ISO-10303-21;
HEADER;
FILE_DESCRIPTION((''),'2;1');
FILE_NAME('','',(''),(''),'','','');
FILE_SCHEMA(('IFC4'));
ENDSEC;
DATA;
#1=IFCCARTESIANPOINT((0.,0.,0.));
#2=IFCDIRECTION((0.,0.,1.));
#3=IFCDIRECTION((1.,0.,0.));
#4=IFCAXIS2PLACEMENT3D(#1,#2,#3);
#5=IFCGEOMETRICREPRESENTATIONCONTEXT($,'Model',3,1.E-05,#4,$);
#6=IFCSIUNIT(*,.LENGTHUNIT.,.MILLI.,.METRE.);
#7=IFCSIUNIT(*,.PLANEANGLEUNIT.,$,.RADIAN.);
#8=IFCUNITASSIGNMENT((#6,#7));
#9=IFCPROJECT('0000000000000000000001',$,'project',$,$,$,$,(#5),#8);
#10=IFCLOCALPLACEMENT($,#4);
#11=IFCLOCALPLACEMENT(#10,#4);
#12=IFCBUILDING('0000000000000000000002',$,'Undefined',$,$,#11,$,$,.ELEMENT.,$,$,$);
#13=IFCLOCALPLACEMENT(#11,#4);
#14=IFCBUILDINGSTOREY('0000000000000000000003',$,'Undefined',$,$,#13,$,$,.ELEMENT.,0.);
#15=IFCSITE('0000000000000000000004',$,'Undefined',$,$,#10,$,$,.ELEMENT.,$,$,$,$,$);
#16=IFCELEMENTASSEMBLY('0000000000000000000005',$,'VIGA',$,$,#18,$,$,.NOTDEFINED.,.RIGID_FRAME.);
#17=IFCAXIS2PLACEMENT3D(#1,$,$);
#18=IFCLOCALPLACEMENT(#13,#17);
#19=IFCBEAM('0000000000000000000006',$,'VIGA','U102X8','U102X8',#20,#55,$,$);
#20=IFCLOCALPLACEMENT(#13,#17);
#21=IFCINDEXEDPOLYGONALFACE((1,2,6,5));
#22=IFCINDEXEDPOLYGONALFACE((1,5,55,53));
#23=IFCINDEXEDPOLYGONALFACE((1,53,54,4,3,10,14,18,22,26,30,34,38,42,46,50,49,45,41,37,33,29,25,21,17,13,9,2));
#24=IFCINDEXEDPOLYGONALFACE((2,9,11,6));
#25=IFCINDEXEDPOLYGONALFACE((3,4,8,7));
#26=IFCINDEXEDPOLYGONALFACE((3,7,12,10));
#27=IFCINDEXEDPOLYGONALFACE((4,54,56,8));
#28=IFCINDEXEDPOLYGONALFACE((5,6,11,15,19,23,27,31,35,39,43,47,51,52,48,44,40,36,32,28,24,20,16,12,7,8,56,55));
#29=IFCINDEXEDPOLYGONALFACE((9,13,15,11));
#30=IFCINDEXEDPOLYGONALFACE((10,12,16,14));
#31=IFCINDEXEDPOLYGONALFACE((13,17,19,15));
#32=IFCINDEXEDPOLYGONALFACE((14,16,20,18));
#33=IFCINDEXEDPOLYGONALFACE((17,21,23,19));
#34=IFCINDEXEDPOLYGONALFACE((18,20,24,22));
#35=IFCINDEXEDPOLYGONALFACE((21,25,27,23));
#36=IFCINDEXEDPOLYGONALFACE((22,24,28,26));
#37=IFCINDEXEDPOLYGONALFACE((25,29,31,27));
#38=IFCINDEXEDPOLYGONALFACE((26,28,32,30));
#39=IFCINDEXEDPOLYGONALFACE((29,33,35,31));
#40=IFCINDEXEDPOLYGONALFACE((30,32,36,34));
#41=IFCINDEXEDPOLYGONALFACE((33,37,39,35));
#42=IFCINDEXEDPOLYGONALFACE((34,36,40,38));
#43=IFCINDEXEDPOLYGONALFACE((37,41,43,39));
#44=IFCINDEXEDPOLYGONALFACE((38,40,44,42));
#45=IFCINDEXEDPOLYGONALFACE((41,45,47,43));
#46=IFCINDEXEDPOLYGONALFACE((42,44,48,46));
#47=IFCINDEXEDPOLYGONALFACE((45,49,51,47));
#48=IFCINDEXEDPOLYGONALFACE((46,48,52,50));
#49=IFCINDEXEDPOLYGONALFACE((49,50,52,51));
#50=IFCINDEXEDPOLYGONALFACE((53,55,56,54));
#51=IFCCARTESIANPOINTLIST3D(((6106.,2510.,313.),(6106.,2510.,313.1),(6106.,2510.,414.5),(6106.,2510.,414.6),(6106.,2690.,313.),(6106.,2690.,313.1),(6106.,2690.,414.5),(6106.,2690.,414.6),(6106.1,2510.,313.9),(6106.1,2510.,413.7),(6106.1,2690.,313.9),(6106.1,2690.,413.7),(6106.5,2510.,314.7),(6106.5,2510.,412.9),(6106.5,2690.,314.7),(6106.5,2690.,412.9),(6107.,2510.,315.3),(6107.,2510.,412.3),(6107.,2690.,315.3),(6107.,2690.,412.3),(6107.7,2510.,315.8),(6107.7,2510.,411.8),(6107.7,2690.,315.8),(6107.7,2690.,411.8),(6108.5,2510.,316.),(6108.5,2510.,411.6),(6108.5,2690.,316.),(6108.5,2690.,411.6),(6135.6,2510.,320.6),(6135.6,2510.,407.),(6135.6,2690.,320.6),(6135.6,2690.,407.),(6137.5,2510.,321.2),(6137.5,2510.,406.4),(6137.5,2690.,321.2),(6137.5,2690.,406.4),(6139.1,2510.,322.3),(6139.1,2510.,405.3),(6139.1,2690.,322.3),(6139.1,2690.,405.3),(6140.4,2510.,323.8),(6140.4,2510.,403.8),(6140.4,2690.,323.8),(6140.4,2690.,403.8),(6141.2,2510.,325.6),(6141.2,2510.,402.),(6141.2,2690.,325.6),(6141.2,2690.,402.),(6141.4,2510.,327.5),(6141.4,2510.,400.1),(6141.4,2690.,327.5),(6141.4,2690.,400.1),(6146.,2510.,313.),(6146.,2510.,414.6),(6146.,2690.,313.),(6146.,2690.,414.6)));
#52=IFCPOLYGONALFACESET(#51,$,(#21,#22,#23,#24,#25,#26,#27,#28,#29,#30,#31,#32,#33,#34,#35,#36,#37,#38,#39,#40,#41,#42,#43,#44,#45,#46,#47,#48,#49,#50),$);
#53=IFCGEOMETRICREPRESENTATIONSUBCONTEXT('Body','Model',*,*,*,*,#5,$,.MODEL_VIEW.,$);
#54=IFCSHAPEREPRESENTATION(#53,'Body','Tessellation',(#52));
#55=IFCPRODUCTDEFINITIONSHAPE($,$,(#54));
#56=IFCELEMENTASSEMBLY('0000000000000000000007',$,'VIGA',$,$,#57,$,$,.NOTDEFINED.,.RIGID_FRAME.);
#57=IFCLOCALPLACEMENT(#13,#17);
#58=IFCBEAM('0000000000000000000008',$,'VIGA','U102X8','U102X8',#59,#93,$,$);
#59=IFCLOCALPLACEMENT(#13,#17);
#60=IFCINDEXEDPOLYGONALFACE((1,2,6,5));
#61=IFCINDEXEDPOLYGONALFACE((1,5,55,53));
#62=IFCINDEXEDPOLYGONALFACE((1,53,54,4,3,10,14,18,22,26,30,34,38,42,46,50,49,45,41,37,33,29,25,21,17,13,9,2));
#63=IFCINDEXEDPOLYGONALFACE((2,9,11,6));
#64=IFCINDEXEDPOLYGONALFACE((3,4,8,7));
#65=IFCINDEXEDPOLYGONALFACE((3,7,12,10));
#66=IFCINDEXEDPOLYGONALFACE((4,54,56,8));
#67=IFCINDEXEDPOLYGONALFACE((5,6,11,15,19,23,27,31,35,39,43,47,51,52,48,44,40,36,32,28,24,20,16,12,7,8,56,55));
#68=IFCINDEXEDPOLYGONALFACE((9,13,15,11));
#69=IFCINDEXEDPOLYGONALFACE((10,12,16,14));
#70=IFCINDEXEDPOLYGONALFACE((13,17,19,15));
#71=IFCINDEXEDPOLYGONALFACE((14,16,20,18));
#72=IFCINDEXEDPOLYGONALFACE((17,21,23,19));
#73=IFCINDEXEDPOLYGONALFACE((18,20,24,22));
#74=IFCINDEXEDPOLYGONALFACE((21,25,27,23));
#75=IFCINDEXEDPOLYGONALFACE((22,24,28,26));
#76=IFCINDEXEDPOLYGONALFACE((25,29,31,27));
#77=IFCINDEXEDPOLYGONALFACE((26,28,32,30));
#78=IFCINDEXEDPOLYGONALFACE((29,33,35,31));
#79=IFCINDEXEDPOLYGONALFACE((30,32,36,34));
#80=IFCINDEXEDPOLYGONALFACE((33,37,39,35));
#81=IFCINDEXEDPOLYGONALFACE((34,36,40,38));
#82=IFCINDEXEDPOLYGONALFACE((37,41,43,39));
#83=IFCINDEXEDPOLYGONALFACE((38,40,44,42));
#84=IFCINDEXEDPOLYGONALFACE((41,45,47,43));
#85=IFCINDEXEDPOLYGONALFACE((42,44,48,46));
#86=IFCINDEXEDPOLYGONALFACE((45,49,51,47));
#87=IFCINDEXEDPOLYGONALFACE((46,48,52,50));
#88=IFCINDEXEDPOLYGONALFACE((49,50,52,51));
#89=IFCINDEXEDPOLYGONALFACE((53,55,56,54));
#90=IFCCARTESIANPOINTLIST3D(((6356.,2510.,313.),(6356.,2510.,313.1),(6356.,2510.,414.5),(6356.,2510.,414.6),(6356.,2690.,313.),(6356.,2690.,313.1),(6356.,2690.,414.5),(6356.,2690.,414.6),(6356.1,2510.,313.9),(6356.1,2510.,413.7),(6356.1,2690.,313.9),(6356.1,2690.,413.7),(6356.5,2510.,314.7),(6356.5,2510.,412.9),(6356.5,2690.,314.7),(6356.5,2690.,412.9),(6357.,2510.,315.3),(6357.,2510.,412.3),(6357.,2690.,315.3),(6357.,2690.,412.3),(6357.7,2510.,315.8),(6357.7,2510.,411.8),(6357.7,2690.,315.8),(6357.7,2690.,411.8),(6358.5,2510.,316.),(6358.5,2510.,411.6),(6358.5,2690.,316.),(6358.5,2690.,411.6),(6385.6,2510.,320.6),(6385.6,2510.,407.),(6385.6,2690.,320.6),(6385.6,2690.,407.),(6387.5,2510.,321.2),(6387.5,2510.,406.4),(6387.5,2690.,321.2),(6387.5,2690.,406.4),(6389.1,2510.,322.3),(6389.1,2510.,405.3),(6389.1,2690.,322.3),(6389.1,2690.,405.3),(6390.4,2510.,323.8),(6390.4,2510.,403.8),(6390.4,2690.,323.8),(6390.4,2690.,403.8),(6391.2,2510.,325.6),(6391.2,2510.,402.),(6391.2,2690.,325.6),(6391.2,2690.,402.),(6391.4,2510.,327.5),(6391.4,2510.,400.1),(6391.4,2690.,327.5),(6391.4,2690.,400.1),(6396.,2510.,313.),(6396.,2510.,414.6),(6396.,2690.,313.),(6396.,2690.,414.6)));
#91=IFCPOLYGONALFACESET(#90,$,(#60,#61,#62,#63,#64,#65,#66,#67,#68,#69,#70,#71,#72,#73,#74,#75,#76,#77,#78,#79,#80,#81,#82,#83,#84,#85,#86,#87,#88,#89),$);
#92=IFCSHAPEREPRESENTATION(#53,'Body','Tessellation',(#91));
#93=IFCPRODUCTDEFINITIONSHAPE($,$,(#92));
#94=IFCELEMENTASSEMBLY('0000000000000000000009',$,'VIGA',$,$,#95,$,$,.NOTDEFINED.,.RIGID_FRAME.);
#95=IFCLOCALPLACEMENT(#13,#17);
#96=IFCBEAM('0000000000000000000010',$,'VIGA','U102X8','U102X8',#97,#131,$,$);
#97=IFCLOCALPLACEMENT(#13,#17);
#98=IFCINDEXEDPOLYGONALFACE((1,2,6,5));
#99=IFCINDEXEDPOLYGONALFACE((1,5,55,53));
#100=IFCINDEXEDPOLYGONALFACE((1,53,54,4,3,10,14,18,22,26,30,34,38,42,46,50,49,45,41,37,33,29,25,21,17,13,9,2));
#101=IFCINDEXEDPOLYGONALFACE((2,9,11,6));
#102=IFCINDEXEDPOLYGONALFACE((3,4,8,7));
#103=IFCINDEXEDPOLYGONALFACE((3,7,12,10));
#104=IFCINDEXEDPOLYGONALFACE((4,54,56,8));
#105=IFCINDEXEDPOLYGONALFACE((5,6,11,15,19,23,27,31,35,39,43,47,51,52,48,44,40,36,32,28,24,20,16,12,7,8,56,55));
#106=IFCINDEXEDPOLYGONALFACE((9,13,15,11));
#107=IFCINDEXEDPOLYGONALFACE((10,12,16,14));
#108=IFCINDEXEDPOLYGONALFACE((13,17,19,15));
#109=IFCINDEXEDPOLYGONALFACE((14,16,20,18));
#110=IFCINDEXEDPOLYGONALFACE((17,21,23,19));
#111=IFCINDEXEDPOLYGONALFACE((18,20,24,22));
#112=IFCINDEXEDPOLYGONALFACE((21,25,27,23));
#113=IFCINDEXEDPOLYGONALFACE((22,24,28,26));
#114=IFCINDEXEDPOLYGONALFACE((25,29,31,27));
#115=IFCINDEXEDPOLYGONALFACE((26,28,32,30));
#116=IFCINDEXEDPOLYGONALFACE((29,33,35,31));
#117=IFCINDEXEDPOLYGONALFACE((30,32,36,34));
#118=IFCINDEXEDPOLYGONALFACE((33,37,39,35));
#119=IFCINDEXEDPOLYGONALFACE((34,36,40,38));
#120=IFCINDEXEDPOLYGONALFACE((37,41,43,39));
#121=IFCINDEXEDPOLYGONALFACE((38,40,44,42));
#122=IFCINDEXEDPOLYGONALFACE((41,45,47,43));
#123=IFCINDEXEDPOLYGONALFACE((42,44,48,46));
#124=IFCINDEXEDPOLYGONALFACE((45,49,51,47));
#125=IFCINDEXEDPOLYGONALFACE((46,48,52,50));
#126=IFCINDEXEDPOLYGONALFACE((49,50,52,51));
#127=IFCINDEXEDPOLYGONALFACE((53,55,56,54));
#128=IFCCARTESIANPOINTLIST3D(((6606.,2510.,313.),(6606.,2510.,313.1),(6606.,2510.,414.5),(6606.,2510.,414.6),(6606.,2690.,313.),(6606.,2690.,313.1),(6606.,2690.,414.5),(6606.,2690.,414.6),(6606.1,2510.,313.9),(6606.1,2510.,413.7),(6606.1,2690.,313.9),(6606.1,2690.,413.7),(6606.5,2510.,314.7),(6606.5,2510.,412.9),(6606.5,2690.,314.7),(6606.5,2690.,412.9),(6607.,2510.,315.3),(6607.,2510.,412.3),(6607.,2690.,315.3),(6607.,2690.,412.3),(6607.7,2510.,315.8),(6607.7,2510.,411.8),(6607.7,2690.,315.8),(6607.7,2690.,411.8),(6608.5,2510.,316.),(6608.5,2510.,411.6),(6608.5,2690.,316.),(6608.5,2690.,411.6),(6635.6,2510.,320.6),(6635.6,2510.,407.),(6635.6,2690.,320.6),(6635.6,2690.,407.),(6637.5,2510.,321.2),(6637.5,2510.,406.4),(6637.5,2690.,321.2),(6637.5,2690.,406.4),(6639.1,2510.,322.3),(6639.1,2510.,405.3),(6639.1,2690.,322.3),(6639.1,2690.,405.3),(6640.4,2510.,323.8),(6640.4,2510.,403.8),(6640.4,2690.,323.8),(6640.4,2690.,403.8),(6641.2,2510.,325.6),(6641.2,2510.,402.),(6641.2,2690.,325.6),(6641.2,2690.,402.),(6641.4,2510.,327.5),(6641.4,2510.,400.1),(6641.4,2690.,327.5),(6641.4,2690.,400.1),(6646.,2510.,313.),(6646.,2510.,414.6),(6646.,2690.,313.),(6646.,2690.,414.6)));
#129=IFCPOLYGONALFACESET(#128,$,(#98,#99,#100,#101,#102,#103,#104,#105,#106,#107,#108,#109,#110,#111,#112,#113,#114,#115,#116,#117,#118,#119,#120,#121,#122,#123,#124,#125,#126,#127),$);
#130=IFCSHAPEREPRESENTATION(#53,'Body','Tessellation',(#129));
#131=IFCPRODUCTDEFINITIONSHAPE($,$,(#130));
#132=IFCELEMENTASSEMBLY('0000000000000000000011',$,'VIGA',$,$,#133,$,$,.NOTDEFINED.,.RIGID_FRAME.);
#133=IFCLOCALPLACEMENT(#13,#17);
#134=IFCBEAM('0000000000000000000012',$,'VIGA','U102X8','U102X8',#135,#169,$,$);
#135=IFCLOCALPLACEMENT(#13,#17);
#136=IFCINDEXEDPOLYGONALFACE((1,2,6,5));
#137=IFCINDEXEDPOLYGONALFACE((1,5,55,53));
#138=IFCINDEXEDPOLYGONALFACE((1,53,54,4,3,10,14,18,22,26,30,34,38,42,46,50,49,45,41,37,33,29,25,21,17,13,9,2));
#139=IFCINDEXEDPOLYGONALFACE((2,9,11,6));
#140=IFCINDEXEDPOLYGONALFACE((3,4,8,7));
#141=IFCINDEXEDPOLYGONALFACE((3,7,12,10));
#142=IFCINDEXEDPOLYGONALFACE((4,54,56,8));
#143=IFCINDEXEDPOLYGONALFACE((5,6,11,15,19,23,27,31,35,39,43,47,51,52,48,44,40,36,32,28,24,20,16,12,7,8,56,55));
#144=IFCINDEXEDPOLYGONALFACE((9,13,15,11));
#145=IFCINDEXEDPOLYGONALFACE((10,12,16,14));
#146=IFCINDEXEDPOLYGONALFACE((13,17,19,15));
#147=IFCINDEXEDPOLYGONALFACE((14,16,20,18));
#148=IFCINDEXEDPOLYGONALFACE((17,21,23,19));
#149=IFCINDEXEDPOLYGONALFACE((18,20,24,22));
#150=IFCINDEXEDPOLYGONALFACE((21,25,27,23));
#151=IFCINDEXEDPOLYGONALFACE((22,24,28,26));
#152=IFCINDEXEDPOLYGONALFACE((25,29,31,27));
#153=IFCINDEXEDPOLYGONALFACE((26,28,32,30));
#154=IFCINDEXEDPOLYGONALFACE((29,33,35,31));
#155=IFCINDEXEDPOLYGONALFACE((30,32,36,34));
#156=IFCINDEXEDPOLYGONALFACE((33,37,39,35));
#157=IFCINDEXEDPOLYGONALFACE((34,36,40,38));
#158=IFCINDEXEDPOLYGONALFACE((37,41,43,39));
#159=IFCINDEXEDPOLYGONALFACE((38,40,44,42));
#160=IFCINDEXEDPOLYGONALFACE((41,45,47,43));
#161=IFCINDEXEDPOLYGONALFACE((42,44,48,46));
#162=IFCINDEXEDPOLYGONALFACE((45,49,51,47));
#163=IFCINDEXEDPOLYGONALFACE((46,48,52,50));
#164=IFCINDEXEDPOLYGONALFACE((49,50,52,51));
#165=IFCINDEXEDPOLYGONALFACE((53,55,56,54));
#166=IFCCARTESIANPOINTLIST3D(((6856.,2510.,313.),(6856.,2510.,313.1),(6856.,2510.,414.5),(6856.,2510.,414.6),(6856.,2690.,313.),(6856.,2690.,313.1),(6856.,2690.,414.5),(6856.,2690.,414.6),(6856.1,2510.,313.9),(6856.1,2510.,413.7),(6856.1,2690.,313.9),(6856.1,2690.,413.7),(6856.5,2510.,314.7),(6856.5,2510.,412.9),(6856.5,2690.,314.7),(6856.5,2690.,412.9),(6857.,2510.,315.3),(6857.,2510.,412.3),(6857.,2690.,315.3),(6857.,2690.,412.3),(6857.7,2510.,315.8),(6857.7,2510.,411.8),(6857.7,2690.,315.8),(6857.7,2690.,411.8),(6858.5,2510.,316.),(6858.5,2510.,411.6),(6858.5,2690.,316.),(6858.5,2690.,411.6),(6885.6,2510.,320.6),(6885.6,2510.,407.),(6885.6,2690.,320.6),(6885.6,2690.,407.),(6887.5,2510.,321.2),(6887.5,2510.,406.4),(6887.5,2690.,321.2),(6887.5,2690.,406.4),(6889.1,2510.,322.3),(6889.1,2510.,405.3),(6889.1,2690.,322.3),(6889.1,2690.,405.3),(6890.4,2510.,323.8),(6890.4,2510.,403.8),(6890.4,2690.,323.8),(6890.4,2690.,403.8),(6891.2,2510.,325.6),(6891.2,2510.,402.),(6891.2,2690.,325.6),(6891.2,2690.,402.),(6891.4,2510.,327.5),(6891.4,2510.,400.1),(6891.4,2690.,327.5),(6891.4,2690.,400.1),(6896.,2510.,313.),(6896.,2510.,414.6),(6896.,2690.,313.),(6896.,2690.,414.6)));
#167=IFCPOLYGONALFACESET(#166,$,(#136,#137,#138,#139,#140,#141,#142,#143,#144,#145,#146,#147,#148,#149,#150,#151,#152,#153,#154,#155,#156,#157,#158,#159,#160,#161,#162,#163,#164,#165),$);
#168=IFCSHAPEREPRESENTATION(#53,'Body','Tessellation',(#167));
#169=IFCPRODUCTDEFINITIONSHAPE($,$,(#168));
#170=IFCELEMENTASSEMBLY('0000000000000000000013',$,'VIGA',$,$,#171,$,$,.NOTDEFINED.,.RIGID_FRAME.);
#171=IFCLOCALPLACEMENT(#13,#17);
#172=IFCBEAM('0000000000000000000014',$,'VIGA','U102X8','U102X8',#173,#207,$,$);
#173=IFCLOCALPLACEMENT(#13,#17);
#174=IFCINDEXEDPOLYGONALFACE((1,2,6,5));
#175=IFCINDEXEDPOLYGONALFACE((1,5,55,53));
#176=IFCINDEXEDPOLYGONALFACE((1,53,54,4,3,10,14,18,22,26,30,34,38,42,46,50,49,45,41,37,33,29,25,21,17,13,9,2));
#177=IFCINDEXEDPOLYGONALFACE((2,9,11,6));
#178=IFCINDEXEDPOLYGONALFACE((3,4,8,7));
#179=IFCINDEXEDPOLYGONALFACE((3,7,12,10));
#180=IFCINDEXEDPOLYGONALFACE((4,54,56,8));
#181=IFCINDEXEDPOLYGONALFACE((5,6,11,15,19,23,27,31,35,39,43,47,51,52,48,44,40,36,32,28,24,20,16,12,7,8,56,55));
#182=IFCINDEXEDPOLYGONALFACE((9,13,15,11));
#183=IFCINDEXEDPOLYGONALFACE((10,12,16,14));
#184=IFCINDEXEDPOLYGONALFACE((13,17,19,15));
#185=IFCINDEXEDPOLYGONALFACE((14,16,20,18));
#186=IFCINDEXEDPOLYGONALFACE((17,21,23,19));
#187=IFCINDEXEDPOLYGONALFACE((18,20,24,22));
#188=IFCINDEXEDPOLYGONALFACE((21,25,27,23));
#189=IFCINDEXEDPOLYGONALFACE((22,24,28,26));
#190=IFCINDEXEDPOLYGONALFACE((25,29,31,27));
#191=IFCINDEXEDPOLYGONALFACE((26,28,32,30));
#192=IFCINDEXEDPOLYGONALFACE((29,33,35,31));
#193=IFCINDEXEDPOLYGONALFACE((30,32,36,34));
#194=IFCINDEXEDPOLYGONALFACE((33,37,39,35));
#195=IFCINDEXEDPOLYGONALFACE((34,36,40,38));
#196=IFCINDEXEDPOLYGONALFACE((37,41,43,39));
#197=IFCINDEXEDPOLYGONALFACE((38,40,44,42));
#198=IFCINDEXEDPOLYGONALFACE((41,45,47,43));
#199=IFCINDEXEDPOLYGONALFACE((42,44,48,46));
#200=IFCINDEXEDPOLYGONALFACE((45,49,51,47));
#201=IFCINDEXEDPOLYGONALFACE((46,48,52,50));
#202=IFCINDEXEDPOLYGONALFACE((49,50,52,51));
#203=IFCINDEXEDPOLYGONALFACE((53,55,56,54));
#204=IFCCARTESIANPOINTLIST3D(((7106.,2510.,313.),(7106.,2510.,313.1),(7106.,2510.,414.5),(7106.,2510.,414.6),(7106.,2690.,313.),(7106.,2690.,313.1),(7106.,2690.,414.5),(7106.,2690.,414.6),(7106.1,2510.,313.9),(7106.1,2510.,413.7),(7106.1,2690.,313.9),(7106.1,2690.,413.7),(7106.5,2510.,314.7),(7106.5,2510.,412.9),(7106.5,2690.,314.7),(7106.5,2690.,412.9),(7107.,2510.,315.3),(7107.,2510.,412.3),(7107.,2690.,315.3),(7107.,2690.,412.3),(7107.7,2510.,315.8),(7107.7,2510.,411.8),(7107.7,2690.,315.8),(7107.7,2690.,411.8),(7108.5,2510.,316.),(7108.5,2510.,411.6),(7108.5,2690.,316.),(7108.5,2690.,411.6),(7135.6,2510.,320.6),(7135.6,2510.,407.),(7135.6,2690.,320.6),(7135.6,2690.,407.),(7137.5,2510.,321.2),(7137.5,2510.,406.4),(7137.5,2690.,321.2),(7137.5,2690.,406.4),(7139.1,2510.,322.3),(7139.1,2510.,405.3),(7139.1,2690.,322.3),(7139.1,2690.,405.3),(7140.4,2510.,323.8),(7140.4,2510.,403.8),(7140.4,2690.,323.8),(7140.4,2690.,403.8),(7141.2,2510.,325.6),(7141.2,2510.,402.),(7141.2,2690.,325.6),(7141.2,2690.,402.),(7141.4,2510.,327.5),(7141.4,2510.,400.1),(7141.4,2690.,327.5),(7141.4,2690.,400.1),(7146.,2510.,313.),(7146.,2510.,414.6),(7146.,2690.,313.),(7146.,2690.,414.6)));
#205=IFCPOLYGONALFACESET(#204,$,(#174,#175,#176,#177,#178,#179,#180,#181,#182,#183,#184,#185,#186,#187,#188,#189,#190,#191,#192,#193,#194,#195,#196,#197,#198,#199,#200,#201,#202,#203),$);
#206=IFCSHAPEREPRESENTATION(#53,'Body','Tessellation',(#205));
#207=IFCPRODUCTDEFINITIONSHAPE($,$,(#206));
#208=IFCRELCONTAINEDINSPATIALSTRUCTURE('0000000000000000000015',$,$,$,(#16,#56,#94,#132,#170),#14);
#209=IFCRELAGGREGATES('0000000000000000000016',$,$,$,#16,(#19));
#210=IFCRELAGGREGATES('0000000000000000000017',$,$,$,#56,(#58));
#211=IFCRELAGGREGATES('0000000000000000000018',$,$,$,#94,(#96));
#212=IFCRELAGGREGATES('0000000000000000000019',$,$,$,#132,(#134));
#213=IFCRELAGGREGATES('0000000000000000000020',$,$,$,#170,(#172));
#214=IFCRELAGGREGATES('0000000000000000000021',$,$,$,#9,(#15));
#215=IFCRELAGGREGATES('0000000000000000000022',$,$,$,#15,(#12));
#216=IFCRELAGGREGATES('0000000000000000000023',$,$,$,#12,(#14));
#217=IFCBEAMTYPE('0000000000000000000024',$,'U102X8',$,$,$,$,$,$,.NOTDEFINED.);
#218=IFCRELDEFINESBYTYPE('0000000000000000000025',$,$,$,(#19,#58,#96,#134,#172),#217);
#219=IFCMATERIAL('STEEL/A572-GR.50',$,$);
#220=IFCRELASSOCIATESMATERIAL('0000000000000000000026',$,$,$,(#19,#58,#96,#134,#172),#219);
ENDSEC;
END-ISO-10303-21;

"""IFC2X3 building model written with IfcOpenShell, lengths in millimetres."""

from ifc_helpers import new_model, si_unit, frame, origin_with_axes, origin_2d_with_axis, place, context, subcontext, project, spatial, u_section, extrude, material, type_object, element, aggregate, save


model = new_model("IFC2X3")

# Units and contexts
model_context = context("Model", 3, precision=1e-05, world=origin_with_axes())
body_context = subcontext(model_context, "Body", "Model", "MODEL_VIEW")
ifc_project = project(units=[si_unit("LENGTHUNIT", "METRE", prefix="MILLI"), si_unit("PLANEANGLEUNIT", "RADIAN")], contexts=[model_context])

# Site, building, storey
site_placement = place(None, origin_with_axes())
site = spatial("IfcSite", under=ifc_project, at=site_placement, Name="Undefined", CompositionType="ELEMENT")
building_placement = place(site_placement, origin_with_axes())
building = spatial("IfcBuilding", under=site, at=building_placement, Name="Undefined", CompositionType="ELEMENT")
storey_placement = place(building_placement, origin_with_axes())
storey = spatial("IfcBuildingStorey", under=building, at=storey_placement, Name="Undefined", CompositionType="ELEMENT", Elevation=0.0)

# Element assemblies, beams
assembly_1_placement = place(storey_placement, origin_with_axes())
assembly_1 = element("IfcElementAssembly", 1, at=assembly_1_placement, inside=storey, Name="VIGA", AssemblyPlace="NOTDEFINED", PredefinedType="RIGID_FRAME")
ifc_material_1 = material(Name="STEEL/A572-GR.50")
beam_type = type_object("IfcBeamType", Name="U102X8", PredefinedType="NOTDEFINED")
beam_1_placement = place(assembly_1_placement, frame((6126.0, 2690.0, 363.8), z_axis=(0.0, 0.0, 1.0), x_axis=(0.0, -1.0, 0.0)))
beam_1 = element("IfcBeam", 2, at=beam_1_placement, type_object=beam_type, material=ifc_material_1, Name="VIGA", Description="U102X8", ObjectType="U102X8", context=body_context, shape_type="SweptSolid", body=[
    extrude(u_section(Depth=101.6, FlangeWidth=40.0, WebThickness=4.6, FlangeThickness=6.0, FilletRadius=7.0, EdgeRadius=3.0, FlangeSlope=0.16839, at=origin_2d_with_axis()), frame((180.0, 0.0, 0.0), z_axis=(-1.0, 0.0, 0.0), x_axis=(0.0, -1.0, 0.0)), (0.0, 0.0, 1.0), 180.0),
])
aggregate(assembly_1, [beam_1])
assembly_2_placement = place(storey_placement, origin_with_axes())
assembly_2 = element("IfcElementAssembly", 3, at=assembly_2_placement, inside=storey, Name="VIGA", AssemblyPlace="NOTDEFINED", PredefinedType="RIGID_FRAME")
beam_2_placement = place(assembly_2_placement, frame((6376.0, 2690.0, 363.8), z_axis=(0.0, 0.0, 1.0), x_axis=(0.0, -1.0, 0.0)))
beam_2 = element("IfcBeam", 4, at=beam_2_placement, type_object=beam_type, material=ifc_material_1, Name="VIGA", Description="U102X8", ObjectType="U102X8", context=body_context, shape_type="SweptSolid", body=[
    extrude(u_section(Depth=101.6, FlangeWidth=40.0, WebThickness=4.6, FlangeThickness=6.0, FilletRadius=7.0, EdgeRadius=3.0, FlangeSlope=0.16839, at=origin_2d_with_axis()), frame((180.0, 0.0, 0.0), z_axis=(-1.0, 0.0, 0.0), x_axis=(0.0, -1.0, 0.0)), (0.0, 0.0, 1.0), 180.0),
])
aggregate(assembly_2, [beam_2])
assembly_3_placement = place(storey_placement, origin_with_axes())
assembly_3 = element("IfcElementAssembly", 5, at=assembly_3_placement, inside=storey, Name="VIGA", AssemblyPlace="NOTDEFINED", PredefinedType="RIGID_FRAME")
beam_3_placement = place(assembly_3_placement, frame((6626.0, 2690.0, 363.8), z_axis=(0.0, 0.0, 1.0), x_axis=(0.0, -1.0, 0.0)))
beam_3 = element("IfcBeam", 6, at=beam_3_placement, type_object=beam_type, material=ifc_material_1, Name="VIGA", Description="U102X8", ObjectType="U102X8", context=body_context, shape_type="SweptSolid", body=[
    extrude(u_section(Depth=101.6, FlangeWidth=40.0, WebThickness=4.6, FlangeThickness=6.0, FilletRadius=7.0, EdgeRadius=3.0, FlangeSlope=0.16839, at=origin_2d_with_axis()), frame((180.0, 0.0, 0.0), z_axis=(-1.0, 0.0, 0.0), x_axis=(0.0, -1.0, 0.0)), (0.0, 0.0, 1.0), 180.0),
])
aggregate(assembly_3, [beam_3])
assembly_4_placement = place(storey_placement, origin_with_axes())
assembly_4 = element("IfcElementAssembly", 7, at=assembly_4_placement, inside=storey, Name="VIGA", AssemblyPlace="NOTDEFINED", PredefinedType="RIGID_FRAME")
beam_4_placement = place(assembly_4_placement, frame((6876.0, 2690.0, 363.8), z_axis=(0.0, 0.0, 1.0), x_axis=(0.0, -1.0, 0.0)))
beam_4 = element("IfcBeam", 8, at=beam_4_placement, type_object=beam_type, material=ifc_material_1, Name="VIGA", Description="U102X8", ObjectType="U102X8", context=body_context, shape_type="SweptSolid", body=[
    extrude(u_section(Depth=101.6, FlangeWidth=40.0, WebThickness=4.6, FlangeThickness=6.0, FilletRadius=7.0, EdgeRadius=3.0, FlangeSlope=0.16839, at=origin_2d_with_axis()), frame((180.0, 0.0, 0.0), z_axis=(-1.0, 0.0, 0.0), x_axis=(0.0, -1.0, 0.0)), (0.0, 0.0, 1.0), 180.0),
])
aggregate(assembly_4, [beam_4])
assembly_5_placement = place(storey_placement, origin_with_axes())
assembly_5 = element("IfcElementAssembly", 9, at=assembly_5_placement, inside=storey, Name="VIGA", AssemblyPlace="NOTDEFINED", PredefinedType="RIGID_FRAME")
beam_5_placement = place(assembly_5_placement, frame((7126.0, 2690.0, 363.8), z_axis=(0.0, 0.0, 1.0), x_axis=(0.0, -1.0, 0.0)))
beam_5 = element("IfcBeam", 10, at=beam_5_placement, type_object=beam_type, material=ifc_material_1, Name="VIGA", Description="U102X8", ObjectType="U102X8", context=body_context, shape_type="SweptSolid", body=[
    extrude(u_section(Depth=101.6, FlangeWidth=40.0, WebThickness=4.6, FlangeThickness=6.0, FilletRadius=7.0, EdgeRadius=3.0, FlangeSlope=0.16839, at=origin_2d_with_axis()), frame((180.0, 0.0, 0.0), z_axis=(-1.0, 0.0, 0.0), x_axis=(0.0, -1.0, 0.0)), (0.0, 0.0, 1.0), 180.0),
])
aggregate(assembly_5, [beam_5])

save(model, "model.ifc")
